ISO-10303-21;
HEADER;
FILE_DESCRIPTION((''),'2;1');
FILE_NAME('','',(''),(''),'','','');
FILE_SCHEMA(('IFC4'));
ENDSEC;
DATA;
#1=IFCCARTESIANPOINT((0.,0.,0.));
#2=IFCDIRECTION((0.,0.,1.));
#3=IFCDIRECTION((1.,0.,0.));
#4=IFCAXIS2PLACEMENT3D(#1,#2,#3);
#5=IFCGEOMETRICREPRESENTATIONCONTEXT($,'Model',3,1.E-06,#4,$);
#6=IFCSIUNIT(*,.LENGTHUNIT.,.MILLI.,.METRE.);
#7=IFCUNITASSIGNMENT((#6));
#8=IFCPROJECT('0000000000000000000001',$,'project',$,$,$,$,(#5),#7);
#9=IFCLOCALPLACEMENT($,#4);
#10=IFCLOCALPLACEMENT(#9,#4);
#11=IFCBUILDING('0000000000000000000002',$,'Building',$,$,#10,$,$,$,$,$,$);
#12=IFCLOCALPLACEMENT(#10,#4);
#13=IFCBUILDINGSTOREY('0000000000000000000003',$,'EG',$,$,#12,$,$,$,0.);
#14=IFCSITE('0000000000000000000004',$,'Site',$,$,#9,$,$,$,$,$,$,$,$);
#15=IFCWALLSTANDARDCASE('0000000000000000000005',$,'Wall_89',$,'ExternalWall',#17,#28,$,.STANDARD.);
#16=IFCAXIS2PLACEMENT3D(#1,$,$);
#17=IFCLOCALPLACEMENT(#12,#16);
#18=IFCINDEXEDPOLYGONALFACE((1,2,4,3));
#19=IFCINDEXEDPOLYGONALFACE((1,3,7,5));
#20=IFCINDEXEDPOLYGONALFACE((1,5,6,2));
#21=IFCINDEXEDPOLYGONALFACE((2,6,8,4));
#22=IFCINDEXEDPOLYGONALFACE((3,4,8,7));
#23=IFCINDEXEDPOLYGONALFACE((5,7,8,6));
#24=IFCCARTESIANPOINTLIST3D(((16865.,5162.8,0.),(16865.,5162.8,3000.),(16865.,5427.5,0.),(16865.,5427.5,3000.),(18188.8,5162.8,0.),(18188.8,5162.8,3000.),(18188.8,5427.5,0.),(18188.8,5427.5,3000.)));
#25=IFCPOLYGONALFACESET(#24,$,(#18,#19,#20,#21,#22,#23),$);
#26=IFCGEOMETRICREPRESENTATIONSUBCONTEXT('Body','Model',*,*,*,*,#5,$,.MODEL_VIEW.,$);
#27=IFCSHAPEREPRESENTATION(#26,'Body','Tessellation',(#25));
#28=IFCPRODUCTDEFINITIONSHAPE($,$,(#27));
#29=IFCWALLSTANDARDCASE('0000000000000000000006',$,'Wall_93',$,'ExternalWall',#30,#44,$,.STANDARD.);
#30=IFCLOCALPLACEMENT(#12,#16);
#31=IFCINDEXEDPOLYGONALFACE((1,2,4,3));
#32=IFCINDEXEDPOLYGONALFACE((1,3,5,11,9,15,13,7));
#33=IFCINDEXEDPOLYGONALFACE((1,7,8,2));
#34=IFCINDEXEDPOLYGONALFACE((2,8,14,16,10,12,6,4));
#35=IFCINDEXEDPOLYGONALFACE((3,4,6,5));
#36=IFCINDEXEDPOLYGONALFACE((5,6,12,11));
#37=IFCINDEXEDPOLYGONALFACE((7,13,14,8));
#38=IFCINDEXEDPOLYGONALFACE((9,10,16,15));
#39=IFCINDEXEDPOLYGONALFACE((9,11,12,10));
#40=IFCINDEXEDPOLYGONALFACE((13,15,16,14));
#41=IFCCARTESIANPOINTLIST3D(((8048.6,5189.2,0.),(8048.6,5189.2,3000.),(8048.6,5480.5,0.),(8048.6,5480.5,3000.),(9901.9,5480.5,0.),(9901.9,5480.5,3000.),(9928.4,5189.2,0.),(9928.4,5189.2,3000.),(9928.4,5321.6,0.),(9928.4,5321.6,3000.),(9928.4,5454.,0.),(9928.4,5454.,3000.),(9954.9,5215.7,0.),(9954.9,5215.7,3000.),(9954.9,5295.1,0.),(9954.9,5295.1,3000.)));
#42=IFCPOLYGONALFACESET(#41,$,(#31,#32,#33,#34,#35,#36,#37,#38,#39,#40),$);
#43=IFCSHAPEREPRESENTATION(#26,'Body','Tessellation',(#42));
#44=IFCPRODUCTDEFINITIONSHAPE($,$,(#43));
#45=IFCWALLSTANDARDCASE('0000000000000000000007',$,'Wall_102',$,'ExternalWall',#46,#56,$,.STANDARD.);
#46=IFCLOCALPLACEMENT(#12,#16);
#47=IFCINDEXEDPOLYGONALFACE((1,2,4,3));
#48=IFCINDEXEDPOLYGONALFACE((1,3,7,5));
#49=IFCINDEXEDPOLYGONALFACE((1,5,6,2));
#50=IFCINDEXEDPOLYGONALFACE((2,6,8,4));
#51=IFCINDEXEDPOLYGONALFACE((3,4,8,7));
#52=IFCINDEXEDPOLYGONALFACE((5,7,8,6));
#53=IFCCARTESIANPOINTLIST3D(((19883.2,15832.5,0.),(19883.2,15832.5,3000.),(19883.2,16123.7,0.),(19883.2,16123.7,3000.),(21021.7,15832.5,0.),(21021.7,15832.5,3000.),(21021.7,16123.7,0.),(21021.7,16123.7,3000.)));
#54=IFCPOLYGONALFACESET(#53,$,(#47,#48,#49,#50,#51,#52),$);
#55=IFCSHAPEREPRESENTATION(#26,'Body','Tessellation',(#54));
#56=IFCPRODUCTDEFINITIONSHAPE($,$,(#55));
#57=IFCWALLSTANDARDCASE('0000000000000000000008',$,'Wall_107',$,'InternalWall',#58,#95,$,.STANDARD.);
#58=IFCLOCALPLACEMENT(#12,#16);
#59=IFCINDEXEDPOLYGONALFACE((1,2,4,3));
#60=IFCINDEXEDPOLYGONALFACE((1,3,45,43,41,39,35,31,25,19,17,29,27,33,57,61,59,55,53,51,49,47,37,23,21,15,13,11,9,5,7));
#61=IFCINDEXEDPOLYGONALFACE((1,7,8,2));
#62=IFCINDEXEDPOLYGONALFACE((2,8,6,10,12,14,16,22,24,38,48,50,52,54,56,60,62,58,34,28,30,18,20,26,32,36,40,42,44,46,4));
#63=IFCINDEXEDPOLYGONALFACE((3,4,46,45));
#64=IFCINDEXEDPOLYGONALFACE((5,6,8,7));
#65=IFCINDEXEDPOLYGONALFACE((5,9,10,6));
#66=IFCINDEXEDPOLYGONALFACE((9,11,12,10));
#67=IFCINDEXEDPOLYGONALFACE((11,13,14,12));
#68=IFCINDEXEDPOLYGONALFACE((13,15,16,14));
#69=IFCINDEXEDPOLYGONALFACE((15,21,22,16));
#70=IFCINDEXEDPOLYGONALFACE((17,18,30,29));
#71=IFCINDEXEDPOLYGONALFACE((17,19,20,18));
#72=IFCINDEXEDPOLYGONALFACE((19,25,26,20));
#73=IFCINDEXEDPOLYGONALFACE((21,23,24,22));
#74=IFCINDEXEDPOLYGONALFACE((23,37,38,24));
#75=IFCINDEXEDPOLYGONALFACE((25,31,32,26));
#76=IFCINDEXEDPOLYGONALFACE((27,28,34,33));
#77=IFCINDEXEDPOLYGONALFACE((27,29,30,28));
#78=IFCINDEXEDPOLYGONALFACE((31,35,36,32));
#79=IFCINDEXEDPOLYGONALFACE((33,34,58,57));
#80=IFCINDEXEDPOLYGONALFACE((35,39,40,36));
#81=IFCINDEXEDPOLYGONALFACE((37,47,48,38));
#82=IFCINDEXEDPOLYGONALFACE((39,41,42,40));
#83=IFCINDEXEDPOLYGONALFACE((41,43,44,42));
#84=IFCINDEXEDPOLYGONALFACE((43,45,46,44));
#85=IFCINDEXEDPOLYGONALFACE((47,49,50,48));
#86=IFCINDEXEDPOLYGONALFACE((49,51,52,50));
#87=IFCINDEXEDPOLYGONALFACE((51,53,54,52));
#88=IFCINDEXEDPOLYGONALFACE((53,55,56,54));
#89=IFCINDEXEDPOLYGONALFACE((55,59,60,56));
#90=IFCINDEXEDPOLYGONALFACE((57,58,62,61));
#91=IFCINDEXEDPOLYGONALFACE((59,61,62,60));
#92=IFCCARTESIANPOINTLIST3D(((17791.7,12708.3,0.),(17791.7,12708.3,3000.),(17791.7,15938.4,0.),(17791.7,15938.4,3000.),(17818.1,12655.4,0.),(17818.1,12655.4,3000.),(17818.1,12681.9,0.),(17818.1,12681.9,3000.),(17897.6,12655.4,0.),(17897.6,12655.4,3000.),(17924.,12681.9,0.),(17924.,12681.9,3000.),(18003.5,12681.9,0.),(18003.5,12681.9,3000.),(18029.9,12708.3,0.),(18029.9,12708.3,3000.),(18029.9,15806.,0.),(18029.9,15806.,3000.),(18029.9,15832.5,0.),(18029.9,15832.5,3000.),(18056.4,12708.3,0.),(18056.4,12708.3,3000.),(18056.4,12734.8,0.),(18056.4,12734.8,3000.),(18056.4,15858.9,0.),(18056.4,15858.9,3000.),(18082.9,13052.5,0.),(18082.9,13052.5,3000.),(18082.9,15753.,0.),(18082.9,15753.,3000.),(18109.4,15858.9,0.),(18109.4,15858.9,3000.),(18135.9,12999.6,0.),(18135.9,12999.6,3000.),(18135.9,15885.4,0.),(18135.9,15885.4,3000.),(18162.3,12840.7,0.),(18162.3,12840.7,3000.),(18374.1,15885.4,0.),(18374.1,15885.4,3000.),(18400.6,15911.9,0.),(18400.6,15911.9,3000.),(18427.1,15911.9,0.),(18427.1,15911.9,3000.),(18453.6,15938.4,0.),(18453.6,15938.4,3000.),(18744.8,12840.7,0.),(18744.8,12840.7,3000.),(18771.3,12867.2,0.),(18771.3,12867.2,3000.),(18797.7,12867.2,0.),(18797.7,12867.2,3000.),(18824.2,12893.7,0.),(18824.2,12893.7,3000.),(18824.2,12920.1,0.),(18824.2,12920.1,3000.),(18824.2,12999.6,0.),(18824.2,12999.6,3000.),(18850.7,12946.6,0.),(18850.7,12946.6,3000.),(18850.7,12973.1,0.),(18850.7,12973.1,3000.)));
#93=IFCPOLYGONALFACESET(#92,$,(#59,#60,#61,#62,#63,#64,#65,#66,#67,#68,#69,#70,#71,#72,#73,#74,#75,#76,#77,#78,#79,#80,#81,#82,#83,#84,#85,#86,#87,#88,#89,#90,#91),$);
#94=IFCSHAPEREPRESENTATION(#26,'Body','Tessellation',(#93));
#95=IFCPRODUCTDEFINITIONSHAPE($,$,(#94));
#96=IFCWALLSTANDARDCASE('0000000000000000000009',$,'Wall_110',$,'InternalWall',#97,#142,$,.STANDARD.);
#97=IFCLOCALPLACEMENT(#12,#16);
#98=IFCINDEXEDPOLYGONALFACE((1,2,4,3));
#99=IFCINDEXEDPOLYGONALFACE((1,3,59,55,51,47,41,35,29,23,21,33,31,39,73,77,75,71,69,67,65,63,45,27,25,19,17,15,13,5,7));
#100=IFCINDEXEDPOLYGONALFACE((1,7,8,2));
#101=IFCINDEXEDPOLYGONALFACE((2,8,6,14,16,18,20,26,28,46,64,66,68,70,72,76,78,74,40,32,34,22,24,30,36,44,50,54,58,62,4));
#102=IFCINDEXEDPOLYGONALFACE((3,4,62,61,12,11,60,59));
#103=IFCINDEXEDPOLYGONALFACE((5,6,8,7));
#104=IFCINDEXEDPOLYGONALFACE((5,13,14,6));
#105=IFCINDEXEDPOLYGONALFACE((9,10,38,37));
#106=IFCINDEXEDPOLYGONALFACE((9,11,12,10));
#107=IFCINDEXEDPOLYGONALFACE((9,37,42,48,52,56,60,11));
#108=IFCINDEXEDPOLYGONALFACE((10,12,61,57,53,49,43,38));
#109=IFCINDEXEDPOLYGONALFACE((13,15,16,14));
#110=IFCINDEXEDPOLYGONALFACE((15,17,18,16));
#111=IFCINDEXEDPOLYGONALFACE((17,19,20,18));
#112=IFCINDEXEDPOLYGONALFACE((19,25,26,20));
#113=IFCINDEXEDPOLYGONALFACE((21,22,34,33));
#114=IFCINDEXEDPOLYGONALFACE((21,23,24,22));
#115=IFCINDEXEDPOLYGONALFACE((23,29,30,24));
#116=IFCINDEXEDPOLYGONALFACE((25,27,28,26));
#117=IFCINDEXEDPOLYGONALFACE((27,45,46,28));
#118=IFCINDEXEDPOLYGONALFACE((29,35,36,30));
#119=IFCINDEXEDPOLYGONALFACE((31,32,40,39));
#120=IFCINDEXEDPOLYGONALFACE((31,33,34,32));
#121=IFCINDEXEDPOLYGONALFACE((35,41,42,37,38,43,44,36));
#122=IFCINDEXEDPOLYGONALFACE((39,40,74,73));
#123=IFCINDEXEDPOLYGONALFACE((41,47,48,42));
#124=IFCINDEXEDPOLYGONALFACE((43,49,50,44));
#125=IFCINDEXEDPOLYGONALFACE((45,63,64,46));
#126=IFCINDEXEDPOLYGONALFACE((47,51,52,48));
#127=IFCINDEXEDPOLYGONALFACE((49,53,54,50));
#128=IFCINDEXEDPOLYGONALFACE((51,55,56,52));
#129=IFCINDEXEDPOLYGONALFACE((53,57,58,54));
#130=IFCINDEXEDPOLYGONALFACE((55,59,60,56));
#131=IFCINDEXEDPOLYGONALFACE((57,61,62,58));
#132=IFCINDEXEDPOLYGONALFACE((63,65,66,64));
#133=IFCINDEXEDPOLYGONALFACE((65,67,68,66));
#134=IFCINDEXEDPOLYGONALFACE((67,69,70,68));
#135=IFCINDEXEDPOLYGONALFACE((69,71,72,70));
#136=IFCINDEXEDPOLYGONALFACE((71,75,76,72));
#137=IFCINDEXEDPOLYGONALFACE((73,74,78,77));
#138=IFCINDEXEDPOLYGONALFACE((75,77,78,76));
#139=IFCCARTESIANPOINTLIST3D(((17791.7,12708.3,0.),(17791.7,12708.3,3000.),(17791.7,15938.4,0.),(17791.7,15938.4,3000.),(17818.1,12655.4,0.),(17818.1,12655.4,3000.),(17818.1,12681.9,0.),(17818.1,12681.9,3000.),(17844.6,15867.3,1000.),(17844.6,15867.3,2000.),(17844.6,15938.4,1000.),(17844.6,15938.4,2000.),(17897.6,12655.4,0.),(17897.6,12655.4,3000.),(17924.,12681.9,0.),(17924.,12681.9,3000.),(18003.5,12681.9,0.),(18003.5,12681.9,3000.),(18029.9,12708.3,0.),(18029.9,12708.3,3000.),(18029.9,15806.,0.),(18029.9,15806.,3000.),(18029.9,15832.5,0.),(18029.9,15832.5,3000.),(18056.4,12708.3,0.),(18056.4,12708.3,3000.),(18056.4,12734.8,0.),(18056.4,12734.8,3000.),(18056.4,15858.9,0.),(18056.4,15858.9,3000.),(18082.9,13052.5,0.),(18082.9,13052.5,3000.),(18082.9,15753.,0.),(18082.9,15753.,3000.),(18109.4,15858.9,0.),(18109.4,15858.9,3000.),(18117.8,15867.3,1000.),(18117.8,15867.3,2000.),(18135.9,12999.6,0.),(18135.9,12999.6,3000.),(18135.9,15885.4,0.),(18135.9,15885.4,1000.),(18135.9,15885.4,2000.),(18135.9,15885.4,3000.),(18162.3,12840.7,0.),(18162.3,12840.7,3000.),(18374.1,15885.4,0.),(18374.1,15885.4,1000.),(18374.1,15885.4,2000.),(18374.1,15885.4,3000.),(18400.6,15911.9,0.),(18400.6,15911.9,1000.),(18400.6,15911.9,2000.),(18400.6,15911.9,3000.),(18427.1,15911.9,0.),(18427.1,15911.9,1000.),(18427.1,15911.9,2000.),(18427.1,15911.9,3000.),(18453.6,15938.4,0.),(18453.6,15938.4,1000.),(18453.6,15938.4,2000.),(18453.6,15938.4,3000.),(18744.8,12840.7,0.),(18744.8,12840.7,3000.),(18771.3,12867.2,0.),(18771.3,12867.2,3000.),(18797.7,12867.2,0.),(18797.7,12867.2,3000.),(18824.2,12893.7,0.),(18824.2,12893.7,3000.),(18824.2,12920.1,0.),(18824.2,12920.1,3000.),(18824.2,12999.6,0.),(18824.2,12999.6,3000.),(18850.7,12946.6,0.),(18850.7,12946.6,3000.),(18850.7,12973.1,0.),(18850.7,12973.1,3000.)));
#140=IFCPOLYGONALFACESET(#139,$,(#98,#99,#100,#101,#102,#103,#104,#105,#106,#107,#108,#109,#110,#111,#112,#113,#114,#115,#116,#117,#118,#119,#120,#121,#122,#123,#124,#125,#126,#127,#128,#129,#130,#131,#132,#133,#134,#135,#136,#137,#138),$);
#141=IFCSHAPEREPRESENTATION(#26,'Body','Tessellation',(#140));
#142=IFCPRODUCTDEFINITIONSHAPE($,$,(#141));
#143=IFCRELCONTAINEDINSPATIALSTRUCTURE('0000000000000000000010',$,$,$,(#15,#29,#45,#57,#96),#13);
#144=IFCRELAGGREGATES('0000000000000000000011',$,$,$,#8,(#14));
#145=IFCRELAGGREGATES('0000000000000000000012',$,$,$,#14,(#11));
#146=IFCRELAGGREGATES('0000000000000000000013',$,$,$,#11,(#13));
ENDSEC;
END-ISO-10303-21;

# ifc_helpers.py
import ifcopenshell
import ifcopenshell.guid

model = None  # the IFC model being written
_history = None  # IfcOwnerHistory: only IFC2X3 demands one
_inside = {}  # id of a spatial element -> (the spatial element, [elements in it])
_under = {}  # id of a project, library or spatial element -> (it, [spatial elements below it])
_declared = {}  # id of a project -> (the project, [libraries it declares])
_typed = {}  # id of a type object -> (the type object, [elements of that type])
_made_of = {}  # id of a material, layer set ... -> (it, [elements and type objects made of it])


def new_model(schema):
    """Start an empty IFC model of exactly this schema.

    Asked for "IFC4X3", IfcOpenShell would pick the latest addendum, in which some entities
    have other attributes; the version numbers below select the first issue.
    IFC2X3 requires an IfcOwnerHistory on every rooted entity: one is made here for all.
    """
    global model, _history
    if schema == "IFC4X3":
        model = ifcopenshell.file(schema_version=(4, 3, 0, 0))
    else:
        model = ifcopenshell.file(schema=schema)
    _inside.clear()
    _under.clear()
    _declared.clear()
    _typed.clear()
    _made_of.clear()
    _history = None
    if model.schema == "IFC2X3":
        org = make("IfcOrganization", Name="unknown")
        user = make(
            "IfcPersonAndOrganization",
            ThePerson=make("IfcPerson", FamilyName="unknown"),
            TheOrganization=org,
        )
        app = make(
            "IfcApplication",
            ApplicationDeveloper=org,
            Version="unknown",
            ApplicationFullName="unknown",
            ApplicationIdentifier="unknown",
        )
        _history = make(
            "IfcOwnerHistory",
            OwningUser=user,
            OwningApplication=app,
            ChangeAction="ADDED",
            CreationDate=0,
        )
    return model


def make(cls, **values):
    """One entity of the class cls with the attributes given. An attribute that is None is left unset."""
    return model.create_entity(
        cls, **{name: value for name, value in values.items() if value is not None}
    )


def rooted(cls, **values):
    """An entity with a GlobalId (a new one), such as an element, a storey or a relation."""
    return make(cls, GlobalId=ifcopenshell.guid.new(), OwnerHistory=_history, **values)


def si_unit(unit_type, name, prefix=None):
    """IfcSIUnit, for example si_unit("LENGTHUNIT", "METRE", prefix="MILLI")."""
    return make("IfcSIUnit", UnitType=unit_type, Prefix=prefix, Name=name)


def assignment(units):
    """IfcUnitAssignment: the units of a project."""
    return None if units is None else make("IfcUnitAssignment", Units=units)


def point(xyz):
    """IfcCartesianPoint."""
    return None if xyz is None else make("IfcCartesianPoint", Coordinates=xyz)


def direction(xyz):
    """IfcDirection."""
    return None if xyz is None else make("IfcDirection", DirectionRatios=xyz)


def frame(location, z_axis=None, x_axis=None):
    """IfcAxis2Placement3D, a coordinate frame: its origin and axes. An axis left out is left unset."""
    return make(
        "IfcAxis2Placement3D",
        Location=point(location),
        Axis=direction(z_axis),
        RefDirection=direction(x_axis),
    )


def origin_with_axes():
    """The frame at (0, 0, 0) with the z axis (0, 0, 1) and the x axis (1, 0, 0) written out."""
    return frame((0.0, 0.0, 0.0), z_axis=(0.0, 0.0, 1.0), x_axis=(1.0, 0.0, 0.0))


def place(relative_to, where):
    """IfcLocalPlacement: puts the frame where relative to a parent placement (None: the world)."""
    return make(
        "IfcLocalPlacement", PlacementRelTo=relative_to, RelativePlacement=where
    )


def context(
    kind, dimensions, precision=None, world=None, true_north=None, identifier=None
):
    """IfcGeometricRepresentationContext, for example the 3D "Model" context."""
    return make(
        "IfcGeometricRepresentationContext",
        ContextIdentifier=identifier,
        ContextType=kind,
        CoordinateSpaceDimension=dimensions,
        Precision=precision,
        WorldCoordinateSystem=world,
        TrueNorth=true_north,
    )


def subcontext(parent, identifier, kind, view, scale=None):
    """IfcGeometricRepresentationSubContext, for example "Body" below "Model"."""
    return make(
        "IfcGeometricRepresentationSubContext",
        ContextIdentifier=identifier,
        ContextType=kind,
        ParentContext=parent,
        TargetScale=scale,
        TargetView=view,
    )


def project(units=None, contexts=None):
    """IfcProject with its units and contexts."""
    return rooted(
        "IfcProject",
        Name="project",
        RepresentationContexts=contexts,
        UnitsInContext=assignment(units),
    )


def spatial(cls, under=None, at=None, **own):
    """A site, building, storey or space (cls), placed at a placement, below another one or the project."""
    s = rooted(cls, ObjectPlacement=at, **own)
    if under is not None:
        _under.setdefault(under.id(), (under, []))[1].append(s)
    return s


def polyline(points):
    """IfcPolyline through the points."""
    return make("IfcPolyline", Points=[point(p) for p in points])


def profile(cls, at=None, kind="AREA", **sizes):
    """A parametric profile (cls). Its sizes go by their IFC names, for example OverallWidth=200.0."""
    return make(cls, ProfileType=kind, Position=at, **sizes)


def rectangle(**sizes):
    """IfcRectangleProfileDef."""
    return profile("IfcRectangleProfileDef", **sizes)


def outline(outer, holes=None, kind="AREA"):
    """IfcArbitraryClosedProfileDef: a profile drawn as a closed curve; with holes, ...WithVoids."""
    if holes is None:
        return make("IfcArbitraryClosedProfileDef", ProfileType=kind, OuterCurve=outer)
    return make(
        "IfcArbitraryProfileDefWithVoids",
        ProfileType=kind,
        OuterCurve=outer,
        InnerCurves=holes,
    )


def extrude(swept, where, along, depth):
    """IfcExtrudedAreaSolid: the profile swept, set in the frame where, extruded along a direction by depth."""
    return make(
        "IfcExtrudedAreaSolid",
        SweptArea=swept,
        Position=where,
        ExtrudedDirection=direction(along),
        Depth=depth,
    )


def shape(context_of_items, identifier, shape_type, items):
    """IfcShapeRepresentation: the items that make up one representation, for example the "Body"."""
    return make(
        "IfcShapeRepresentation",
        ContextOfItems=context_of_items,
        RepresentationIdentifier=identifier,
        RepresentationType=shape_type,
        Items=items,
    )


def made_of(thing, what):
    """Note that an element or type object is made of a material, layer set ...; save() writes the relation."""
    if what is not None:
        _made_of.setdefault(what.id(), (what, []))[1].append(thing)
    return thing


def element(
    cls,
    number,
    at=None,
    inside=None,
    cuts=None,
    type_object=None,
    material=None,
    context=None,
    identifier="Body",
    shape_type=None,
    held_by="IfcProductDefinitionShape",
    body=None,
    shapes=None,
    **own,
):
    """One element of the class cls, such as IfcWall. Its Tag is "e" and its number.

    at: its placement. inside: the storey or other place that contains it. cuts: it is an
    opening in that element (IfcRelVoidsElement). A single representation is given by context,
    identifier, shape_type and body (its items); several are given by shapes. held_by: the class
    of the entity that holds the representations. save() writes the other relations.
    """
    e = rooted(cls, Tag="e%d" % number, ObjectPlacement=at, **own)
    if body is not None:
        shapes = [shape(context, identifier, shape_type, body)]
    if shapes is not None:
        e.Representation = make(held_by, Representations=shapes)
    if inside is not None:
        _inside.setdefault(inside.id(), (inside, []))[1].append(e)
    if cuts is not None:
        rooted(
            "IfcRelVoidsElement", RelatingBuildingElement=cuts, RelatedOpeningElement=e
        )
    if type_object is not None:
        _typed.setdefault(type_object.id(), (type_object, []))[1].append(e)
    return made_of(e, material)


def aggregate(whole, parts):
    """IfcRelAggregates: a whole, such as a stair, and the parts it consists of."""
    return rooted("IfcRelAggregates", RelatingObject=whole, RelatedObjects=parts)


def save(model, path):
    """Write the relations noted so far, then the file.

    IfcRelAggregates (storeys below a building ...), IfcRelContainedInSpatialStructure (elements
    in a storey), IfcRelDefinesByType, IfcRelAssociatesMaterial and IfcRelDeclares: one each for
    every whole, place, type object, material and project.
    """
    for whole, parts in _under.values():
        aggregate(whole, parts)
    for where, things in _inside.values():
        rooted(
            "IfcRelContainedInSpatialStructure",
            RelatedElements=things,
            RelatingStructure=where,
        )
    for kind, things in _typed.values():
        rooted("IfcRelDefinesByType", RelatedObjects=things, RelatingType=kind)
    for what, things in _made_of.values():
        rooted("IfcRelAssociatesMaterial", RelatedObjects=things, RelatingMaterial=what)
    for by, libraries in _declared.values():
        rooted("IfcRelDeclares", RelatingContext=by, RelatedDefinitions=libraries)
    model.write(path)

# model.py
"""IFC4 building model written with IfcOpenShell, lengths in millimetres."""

from ifc_helpers import new_model, si_unit, frame, origin_with_axes, place, context, subcontext, project, spatial, polyline, rectangle, outline, extrude, element, save


model = new_model("IFC4")

# Units and contexts
model_context = context("Model", 3, precision=1e-06, world=origin_with_axes())
body_context = subcontext(model_context, "Body", "Model", "MODEL_VIEW")
ifc_project = project(units=[si_unit("LENGTHUNIT", "METRE", prefix="MILLI")], contexts=[model_context])

# Site, building, storey
site_placement = place(None, origin_with_axes())
site = spatial("IfcSite", under=ifc_project, at=site_placement, Name="Site")
building_placement = place(site_placement, origin_with_axes())
building = spatial("IfcBuilding", under=site, at=building_placement, Name="Building")
storey_placement = place(building_placement, origin_with_axes())
storey = spatial("IfcBuildingStorey", under=building, at=storey_placement, Name="EG", Elevation=0.0)

# Wall
wall_1_placement = place(storey_placement, origin_with_axes())
element("IfcWallStandardCase", 1, at=wall_1_placement, inside=storey, Name="Wall_89", ObjectType="ExternalWall", PredefinedType="STANDARD", context=body_context, shape_type="SweptSolid", body=[
    extrude(outline(polyline([(16865.0, 5162.8, 0.0), (16865.0, 5427.5, 0.0), (18188.8, 5427.5, 0.0), (18188.8, 5162.8, 0.0), (16865.0, 5162.8, 0.0)])), origin_with_axes(), (0.0, 0.0, 1.0), 3000.0),
])

# Wall
for number, where, z_axis, x_axis, name in (
    (2, (0.0, 0.0, 0.0), (0.0, 0.0, 1.0), (1.0, 0.0, 0.0), "Wall_93"),
):
    element("IfcWallStandardCase", number, at=place(storey_placement, frame(where, z_axis=z_axis, x_axis=x_axis)), inside=storey, Name=name, ObjectType="ExternalWall", PredefinedType="STANDARD", context=body_context, shape_type="SweptSolid", body=[
        extrude(outline(polyline([(8048.6, 5189.2, 0.0), (8048.6, 5480.5, 0.0), (9901.9, 5480.5, 0.0), (9928.4, 5454.0, 0.0), (9928.4, 5321.6, 0.0), (9954.9, 5295.1, 0.0), (9954.9, 5215.7, 0.0), (9928.4, 5189.2, 0.0), (8048.6, 5189.2, 0.0)])), origin_with_axes(), (0.0, 0.0, 1.0), 3000.0),
    ])

# Wall
for number, where, z_axis, x_axis, name in (
    (3, (0.0, 0.0, 0.0), (0.0, 0.0, 1.0), (1.0, 0.0, 0.0), "Wall_102"),
):
    element("IfcWallStandardCase", number, at=place(storey_placement, frame(where, z_axis=z_axis, x_axis=x_axis)), inside=storey, Name=name, ObjectType="ExternalWall", PredefinedType="STANDARD", context=body_context, shape_type="SweptSolid", body=[
        extrude(outline(polyline([(19883.2, 15832.5, 0.0), (19883.2, 16123.7, 0.0), (21021.7, 16123.7, 0.0), (21021.7, 15832.5, 0.0), (19883.2, 15832.5, 0.0)])), origin_with_axes(), (0.0, 0.0, 1.0), 3000.0),
    ])

# Wall
for number, where, z_axis, x_axis, name in (
    (4, (0.0, 0.0, 0.0), (0.0, 0.0, 1.0), (1.0, 0.0, 0.0), "Wall_107"),
):
    element("IfcWallStandardCase", number, at=place(storey_placement, frame(where, z_axis=z_axis, x_axis=x_axis)), inside=storey, Name=name, ObjectType="InternalWall", PredefinedType="STANDARD", context=body_context, shape_type="SweptSolid", body=[
        extrude(outline(polyline([(17818.1, 12655.4, 0.0), (17818.1, 12681.9, 0.0), (17791.7, 12708.3, 0.0), (17791.7, 15938.4, 0.0), (18453.6, 15938.4, 0.0), (18427.1, 15911.9, 0.0), (18400.6, 15911.9, 0.0), (18374.1, 15885.4, 0.0), (18135.9, 15885.4, 0.0), (18109.4, 15858.9, 0.0), (18056.4, 15858.9, 0.0), (18029.9, 15832.5, 0.0), (18029.9, 15806.0, 0.0), (18082.9, 15753.0, 0.0), (18082.9, 13052.5, 0.0), (18135.9, 12999.6, 0.0), (18824.2, 12999.6, 0.0), (18850.7, 12973.1, 0.0), (18850.7, 12946.6, 0.0), (18824.2, 12920.1, 0.0), (18824.2, 12893.7, 0.0), (18797.7, 12867.2, 0.0), (18771.3, 12867.2, 0.0), (18744.8, 12840.7, 0.0), (18162.3, 12840.7, 0.0), (18056.4, 12734.8, 0.0), (18056.4, 12708.3, 0.0), (18029.9, 12708.3, 0.0), (18003.5, 12681.9, 0.0), (17924.0, 12681.9, 0.0), (17897.6, 12655.4, 0.0), (17818.1, 12655.4, 0.0)])), origin_with_axes(), (0.0, 0.0, 1.0), 3000.0),
    ])

# Wall, opening
wall_2_placement = place(storey_placement, origin_with_axes())
wall_2 = element("IfcWallStandardCase", 5, at=wall_2_placement, inside=storey, Name="Wall_110", ObjectType="InternalWall", PredefinedType="STANDARD", context=body_context, shape_type="SweptSolid", body=[
    extrude(outline(polyline([(17818.1, 12655.4, 0.0), (17818.1, 12681.9, 0.0), (17791.7, 12708.3, 0.0), (17791.7, 15938.4, 0.0), (18453.6, 15938.4, 0.0), (18427.1, 15911.9, 0.0), (18400.6, 15911.9, 0.0), (18374.1, 15885.4, 0.0), (18135.9, 15885.4, 0.0), (18109.4, 15858.9, 0.0), (18056.4, 15858.9, 0.0), (18029.9, 15832.5, 0.0), (18029.9, 15806.0, 0.0), (18082.9, 15753.0, 0.0), (18082.9, 13052.5, 0.0), (18135.9, 12999.6, 0.0), (18824.2, 12999.6, 0.0), (18850.7, 12973.1, 0.0), (18850.7, 12946.6, 0.0), (18824.2, 12920.1, 0.0), (18824.2, 12893.7, 0.0), (18797.7, 12867.2, 0.0), (18771.3, 12867.2, 0.0), (18744.8, 12840.7, 0.0), (18162.3, 12840.7, 0.0), (18056.4, 12734.8, 0.0), (18056.4, 12708.3, 0.0), (18029.9, 12708.3, 0.0), (18003.5, 12681.9, 0.0), (17924.0, 12681.9, 0.0), (17897.6, 12655.4, 0.0), (17818.1, 12655.4, 0.0)])), origin_with_axes(), (0.0, 0.0, 1.0), 3000.0),
])
opening_1_placement = place(wall_2_placement, origin_with_axes())
element("IfcOpeningElement", 6, at=opening_1_placement, inside=storey, cuts=wall_2, context=body_context, shape_type="SweptSolid", body=[
    extrude(rectangle(XDim=1985.7, YDim=115.0), frame((18837.5, 15924.8, 1000.0), z_axis=(0.0, 0.0, 1.0), x_axis=(1.0, 0.0, 0.0)), (0.0, 0.0, 1.0), 1000.0),
])

save(model, "model.ifc")
